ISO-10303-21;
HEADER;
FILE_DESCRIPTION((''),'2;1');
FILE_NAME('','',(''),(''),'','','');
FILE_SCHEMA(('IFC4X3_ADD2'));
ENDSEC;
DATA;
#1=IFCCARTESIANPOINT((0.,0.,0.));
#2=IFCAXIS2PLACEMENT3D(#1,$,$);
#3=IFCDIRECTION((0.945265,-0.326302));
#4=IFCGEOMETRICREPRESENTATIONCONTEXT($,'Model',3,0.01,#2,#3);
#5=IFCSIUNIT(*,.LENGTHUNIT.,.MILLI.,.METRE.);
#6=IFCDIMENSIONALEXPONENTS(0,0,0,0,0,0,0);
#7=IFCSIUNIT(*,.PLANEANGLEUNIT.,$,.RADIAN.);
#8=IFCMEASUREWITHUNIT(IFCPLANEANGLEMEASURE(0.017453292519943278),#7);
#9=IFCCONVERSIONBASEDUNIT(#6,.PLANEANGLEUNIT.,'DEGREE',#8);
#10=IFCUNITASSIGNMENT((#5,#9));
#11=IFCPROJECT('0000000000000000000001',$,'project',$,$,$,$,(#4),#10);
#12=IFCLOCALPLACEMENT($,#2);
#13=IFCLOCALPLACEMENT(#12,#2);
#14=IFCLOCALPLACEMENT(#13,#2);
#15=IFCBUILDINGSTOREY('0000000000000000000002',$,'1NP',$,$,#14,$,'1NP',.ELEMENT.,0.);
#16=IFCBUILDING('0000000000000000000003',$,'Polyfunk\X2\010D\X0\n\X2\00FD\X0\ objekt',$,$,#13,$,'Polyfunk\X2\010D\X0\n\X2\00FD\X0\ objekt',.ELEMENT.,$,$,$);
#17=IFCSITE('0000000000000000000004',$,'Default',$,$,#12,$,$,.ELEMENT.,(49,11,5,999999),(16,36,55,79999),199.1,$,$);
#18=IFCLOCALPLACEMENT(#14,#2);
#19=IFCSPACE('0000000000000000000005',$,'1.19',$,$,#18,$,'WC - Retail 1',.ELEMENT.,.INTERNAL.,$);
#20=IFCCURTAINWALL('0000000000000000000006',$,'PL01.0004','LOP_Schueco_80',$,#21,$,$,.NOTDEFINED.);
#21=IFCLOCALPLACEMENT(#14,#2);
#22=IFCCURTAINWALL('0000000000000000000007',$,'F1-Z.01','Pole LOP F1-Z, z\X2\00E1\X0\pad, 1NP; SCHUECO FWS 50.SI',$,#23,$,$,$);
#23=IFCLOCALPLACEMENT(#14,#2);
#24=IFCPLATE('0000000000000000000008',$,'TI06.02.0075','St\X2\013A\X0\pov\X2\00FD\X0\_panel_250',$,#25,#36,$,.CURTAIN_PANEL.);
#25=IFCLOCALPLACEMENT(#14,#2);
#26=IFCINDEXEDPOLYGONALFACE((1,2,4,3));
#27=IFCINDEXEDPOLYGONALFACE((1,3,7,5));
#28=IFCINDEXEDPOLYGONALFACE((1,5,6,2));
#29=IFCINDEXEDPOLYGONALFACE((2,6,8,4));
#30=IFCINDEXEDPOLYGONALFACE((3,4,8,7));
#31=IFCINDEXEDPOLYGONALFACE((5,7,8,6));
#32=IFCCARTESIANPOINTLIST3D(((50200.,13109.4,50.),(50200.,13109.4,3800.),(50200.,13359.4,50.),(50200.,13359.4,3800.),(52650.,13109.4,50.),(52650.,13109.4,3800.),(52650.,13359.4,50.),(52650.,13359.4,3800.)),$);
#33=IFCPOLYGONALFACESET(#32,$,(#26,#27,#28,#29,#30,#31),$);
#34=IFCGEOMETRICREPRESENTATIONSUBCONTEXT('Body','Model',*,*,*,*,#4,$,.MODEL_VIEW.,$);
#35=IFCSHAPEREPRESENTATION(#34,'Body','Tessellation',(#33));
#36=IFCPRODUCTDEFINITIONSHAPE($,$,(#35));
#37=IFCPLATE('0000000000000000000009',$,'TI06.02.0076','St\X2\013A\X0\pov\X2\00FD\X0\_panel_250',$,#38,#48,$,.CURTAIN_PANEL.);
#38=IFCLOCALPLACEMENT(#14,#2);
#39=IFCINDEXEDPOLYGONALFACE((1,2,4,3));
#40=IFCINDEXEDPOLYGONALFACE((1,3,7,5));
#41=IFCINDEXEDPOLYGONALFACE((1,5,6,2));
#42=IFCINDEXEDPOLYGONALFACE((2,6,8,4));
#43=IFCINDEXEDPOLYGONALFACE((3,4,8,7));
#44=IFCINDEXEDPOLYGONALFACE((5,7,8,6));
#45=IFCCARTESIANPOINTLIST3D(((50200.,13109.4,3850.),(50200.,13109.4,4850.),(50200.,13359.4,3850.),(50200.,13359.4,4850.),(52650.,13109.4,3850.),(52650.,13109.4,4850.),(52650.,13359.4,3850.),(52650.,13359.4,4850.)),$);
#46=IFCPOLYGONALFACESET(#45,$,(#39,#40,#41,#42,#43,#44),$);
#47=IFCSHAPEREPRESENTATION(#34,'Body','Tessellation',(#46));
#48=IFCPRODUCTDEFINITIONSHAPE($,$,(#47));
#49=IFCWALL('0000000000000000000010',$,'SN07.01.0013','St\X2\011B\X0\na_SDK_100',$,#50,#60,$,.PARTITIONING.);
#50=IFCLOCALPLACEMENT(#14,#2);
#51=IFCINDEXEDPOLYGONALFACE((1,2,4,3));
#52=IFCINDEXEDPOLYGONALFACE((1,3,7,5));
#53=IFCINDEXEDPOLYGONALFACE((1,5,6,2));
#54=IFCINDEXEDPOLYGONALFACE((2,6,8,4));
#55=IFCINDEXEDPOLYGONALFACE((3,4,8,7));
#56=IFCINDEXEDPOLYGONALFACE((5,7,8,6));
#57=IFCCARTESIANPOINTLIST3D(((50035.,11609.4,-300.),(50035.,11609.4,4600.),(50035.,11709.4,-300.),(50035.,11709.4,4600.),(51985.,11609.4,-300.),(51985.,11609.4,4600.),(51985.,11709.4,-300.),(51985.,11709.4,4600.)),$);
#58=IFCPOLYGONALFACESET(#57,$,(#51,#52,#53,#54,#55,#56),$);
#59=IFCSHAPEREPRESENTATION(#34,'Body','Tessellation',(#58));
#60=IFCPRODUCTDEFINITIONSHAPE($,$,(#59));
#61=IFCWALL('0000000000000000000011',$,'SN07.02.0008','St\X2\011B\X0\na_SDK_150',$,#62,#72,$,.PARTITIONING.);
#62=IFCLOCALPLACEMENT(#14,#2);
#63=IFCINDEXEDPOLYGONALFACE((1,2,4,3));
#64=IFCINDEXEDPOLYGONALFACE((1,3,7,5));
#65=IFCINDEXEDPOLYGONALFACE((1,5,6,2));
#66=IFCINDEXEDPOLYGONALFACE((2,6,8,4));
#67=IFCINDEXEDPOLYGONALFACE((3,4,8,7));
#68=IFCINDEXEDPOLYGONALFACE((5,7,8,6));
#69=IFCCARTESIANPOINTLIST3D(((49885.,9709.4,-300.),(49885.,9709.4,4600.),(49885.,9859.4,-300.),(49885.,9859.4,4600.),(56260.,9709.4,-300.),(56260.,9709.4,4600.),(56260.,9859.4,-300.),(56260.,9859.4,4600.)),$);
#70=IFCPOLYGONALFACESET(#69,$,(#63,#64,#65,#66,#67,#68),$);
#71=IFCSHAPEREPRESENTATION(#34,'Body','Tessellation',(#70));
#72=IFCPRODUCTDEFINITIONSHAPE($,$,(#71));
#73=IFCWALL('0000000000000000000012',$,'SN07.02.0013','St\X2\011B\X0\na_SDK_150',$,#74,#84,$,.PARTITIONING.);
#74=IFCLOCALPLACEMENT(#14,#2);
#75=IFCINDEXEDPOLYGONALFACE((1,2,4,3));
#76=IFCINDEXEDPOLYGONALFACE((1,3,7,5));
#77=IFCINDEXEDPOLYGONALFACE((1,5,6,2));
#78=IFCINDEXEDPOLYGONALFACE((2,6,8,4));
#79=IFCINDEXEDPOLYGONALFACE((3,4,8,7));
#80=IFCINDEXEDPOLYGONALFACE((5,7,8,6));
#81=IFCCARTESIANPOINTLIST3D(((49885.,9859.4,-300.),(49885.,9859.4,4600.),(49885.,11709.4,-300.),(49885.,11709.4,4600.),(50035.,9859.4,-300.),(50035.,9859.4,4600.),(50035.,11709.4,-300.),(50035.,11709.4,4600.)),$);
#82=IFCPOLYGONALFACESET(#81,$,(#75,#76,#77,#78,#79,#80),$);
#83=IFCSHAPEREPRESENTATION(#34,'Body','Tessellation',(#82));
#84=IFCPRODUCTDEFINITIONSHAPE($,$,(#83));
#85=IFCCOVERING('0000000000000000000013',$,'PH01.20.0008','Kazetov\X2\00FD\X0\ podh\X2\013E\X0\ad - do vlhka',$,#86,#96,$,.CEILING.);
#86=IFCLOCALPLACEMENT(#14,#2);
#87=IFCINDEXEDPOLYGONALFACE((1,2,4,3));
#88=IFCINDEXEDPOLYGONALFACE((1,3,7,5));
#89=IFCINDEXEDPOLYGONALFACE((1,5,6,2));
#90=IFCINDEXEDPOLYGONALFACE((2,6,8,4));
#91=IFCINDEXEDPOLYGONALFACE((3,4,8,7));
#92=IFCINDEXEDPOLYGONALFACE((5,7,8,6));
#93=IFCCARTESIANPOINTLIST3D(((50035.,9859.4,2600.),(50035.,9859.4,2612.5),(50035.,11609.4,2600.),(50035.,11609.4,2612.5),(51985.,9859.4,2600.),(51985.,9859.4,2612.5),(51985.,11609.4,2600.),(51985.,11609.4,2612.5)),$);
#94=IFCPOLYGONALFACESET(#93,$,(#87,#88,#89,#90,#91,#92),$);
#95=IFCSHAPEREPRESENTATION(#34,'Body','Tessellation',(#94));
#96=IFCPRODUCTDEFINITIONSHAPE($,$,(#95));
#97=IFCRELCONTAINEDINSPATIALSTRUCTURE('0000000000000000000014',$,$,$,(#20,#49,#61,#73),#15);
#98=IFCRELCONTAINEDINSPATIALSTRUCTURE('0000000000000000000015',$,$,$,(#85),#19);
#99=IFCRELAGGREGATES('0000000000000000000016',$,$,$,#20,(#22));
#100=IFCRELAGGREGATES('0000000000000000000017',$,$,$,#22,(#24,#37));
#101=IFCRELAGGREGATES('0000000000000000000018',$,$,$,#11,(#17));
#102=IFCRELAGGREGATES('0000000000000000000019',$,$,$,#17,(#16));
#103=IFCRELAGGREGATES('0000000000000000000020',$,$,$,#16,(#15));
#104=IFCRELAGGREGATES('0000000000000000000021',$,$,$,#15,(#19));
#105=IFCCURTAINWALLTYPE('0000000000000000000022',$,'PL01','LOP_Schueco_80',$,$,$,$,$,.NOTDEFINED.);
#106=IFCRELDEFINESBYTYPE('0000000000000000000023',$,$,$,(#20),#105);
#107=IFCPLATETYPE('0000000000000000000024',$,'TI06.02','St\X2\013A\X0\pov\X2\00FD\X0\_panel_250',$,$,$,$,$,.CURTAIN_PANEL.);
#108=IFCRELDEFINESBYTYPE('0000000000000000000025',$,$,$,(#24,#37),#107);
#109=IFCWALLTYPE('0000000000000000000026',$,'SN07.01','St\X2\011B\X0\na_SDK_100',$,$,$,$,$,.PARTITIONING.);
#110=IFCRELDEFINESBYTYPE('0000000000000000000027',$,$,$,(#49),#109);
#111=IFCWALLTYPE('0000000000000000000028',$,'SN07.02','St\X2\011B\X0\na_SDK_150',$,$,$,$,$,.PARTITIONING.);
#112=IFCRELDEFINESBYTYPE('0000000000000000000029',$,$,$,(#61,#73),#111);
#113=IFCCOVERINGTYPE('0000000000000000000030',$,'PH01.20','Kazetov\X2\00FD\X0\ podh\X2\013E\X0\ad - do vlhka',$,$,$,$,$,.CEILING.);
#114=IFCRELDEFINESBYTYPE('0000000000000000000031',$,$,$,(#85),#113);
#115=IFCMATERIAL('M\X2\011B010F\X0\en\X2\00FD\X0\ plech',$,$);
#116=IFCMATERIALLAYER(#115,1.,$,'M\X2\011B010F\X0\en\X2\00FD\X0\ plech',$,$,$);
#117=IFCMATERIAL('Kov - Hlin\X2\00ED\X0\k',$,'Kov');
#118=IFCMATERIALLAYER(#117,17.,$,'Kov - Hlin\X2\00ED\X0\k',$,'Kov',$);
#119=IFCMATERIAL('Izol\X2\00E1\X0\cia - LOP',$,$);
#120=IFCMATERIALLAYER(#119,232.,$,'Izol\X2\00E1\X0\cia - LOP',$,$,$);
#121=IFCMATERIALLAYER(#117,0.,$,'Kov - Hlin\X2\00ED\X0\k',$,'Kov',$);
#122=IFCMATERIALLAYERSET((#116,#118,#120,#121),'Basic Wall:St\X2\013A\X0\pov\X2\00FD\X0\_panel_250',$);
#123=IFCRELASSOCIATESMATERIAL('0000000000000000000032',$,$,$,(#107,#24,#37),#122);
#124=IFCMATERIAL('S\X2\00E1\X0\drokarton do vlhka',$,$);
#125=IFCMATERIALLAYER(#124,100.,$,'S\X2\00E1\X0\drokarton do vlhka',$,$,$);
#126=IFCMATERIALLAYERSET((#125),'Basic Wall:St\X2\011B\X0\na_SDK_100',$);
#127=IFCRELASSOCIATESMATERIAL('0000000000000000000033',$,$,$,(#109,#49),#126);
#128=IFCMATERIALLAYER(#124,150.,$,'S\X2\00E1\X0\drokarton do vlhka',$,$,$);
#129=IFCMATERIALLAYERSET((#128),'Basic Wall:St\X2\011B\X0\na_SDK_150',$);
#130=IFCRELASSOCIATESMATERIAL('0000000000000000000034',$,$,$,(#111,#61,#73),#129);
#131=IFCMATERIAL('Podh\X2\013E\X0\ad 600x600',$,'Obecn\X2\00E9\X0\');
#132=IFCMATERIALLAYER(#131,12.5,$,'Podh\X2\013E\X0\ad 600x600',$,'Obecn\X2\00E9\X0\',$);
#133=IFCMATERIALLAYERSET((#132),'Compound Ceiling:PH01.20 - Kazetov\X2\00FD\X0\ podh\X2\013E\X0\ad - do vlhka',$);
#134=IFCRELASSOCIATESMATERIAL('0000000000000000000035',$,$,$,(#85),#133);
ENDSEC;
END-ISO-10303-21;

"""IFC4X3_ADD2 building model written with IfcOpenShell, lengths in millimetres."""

from ifc_helpers import new_model, entity, si_unit, converted_unit, direction, frame, frame_2d, origin, origin_2d_with_axis, place, context, subcontext, project, spatial, polyline, rectangle, extrude, clip, bounded_halfspace, material, layer, layer_set, layer_usage, type_object, element, aggregate, save


model = new_model("IFC4X3_ADD2")

# Units and contexts
model_context = context("Model", 3, precision=0.01, world=origin(), true_north=direction((0.945265, -0.326302)))
body_context = subcontext(model_context, "Body", "Model", "MODEL_VIEW")
ifc_project = project(units=[si_unit("LENGTHUNIT", "METRE", prefix="MILLI"), converted_unit("PLANEANGLEUNIT", "DEGREE", entity("IfcPlaneAngleMeasure", 0.017453292519943278), si_unit("PLANEANGLEUNIT", "RADIAN"), dimensions=[0, 0, 0, 0, 0, 0, 0])], contexts=[model_context])

# Site, building, storey
site_placement = place(None, origin())
site = spatial("IfcSite", under=ifc_project, at=site_placement, Name="Default", CompositionType="ELEMENT", RefLatitude=(49, 11, 5, 999999), RefLongitude=(16, 36, 55, 79999), RefElevation=199.1)
building_placement = place(site_placement, origin())
building = spatial("IfcBuilding", under=site, at=building_placement, Name="Polyfunkčný objekt", LongName="Polyfunkčný objekt", CompositionType="ELEMENT")
storey_placement = place(building_placement, origin())
storey = spatial("IfcBuildingStorey", under=building, at=storey_placement, Name="1NP", LongName="1NP", CompositionType="ELEMENT", Elevation=0.0)

# Curtain walls, plates
curtain_wall_type = type_object("IfcCurtainWallType", Name="PL01", Description="LOP_Schueco_80", PredefinedType="NOTDEFINED")
curtain_wall_1_placement = place(storey_placement, origin())
curtain_wall_1 = element("IfcCurtainWall", 1, at=curtain_wall_1_placement, inside=storey, type_object=curtain_wall_type, Name="PL01.0004", Description="LOP_Schueco_80", PredefinedType="NOTDEFINED")
curtain_wall_2 = element("IfcCurtainWall", 2, Name="F1-Z.01", Description="Pole LOP F1-Z, západ, 1NP; SCHUECO FWS 50.SI")
aggregate(curtain_wall_1, [curtain_wall_2])
ifc_material_1 = material(Name="Měďený plech")
ifc_layer_1 = layer(ifc_material_1, 1.0, Name="Měďený plech")
ifc_material_2 = material(Name="Kov - Hliník", Category="Kov")
ifc_layer_2 = layer(ifc_material_2, 17.0, Name="Kov - Hliník", Category="Kov")
ifc_material_3 = material(Name="Izolácia - LOP")
ifc_layer_3 = layer(ifc_material_3, 232.0, Name="Izolácia - LOP")
ifc_layer_4 = layer(ifc_material_2, 0.0, Name="Kov - Hliník", Category="Kov")
ifc_layer_set_1 = layer_set([ifc_layer_1, ifc_layer_2, ifc_layer_3, ifc_layer_4], Name="Basic Wall:Stĺpový_panel_250")
ifc_layer_usage_1 = layer_usage(ifc_layer_set_1, "AXIS2", "NEGATIVE", 125.0)
plate_type = type_object("IfcPlateType", Name="TI06.02", Description="Stĺpový_panel_250", PredefinedType="CURTAIN_PANEL", material=ifc_layer_set_1)
plate_1_placement = place(storey_placement, frame((50200.0, 13234.4, 50.0)))
plate_1 = element("IfcPlate", 3, at=plate_1_placement, type_object=plate_type, material=ifc_layer_usage_1, Name="TI06.02.0075", Description="Stĺpový_panel_250", PredefinedType="CURTAIN_PANEL", context=body_context, shape_type="SweptSolid", body=[
    extrude(rectangle(XDim=250.0, YDim=2450.0, at=origin_2d_with_axis()), frame((1225.0, 0.0, 0.0), z_axis=(0.0, 0.0, 1.0), x_axis=(0.0, 1.0, 0.0)), (0.0, 0.0, 1.0), 3750.0),
])
ifc_layer_usage_2 = layer_usage(ifc_layer_set_1, "AXIS2", "NEGATIVE", 125.0)
plate_2_placement = place(storey_placement, frame((50200.0, 13234.4, 3850.0)))
plate_2 = element("IfcPlate", 4, at=plate_2_placement, type_object=plate_type, material=ifc_layer_usage_2, Name="TI06.02.0076", Description="Stĺpový_panel_250", PredefinedType="CURTAIN_PANEL", context=body_context, shape_type="SweptSolid", body=[
    extrude(rectangle(XDim=250.0, YDim=2450.0, at=origin_2d_with_axis()), frame((1225.0, 0.0, 0.0), z_axis=(0.0, 0.0, 1.0), x_axis=(0.0, 1.0, 0.0)), (0.0, 0.0, 1.0), 1000.0),
])
aggregate(curtain_wall_2, [plate_1, plate_2])

# Walls
ifc_material_4 = material(Name="Sádrokarton do vlhka")
ifc_layer_5 = layer(ifc_material_4, 100.0, Name="Sádrokarton do vlhka")
ifc_layer_set_2 = layer_set([ifc_layer_5], Name="Basic Wall:Stěna_SDK_100")
wall_type_1 = type_object("IfcWallType", Name="SN07.01", Description="Stěna_SDK_100", PredefinedType="PARTITIONING", material=ifc_layer_set_2)
wall_1_placement = place(storey_placement, frame((51985.0, 11659.4, -300.0), z_axis=(0.0, 0.0, 1.0), x_axis=(-1.0, 0.0, 0.0)))
element("IfcWall", 5, at=wall_1_placement, inside=storey, type_object=wall_type_1, material=ifc_layer_set_2, Name="SN07.01.0013", Description="Stěna_SDK_100", PredefinedType="PARTITIONING", context=body_context, shape_type="Clipping", body=[
    clip(clip(extrude(rectangle(XDim=1950.0, YDim=100.0, at=frame_2d((975.0, 0.0), x_axis=(-1.0, 0.0))), origin(), (0.0, 0.0, 1.0), 4900.0), bounded_halfspace(frame((0.0, -50.0, 4900.0), z_axis=(0.0, 0.0, -1.0), x_axis=(-1.0, 0.0, 0.0)), True, frame((0.0, -50.0, 4900.0)), polyline([(0.0, 0.0), (1950.0, 0.0), (1950.0, 100.0), (1050.0, 100.0), (900.0, 100.0), (0.0, 100.0), (0.0, 0.0)]))), bounded_halfspace(frame((1950.0, -50.0, 0.0), z_axis=(0.0, 0.0, 1.0), x_axis=(0.0, -1.0, 0.0)), True, frame((1950.0, -50.0, 0.0)), polyline([(0.0, 0.0), (0.0, 100.0), (-900.0, 100.0), (-1050.0, 100.0), (-1950.0, 100.0), (-1950.0, 0.0), (0.0, 0.0)]))),
])
ifc_layer_6 = layer(ifc_material_4, 150.0, Name="Sádrokarton do vlhka")
ifc_layer_set_3 = layer_set([ifc_layer_6], Name="Basic Wall:Stěna_SDK_150")
wall_type_2 = type_object("IfcWallType", Name="SN07.02", Description="Stěna_SDK_150", PredefinedType="PARTITIONING", material=ifc_layer_set_3)
wall_2_placement = place(storey_placement, frame((49885.0, 9784.4, -300.0)))
element("IfcWall", 6, at=wall_2_placement, inside=storey, type_object=wall_type_2, material=ifc_layer_set_3, Name="SN07.02.0008", Description="Stěna_SDK_150", PredefinedType="PARTITIONING", context=body_context, shape_type="Clipping", body=[
    clip(clip(extrude(rectangle(XDim=6375.0, YDim=150.0, at=frame_2d((3187.5, 0.0), x_axis=(-1.0, 0.0))), origin(), (0.0, 0.0, 1.0), 4900.0), bounded_halfspace(frame((0.0, -75.0, 4900.0), z_axis=(0.0, 0.0, -1.0), x_axis=(1.0, 0.0, 0.0)), True, frame((0.0, -75.0, 4900.0)), polyline([(0.0, 0.0), (6375.0, 0.0), (6375.0, 150.0), (2250.0, 150.0), (2100.0, 150.0), (1200.0, 150.0), (1050.0, 150.0), (150.0, 150.0), (0.0, 150.0), (0.0, 0.0)]))), bounded_halfspace(frame((6375.0, -75.0, 0.0), z_axis=(0.0, 0.0, 1.0), x_axis=(0.0, 1.0, 0.0)), True, frame((6375.0, -75.0, 0.0)), polyline([(0.0, 0.0), (0.0, 150.0), (-4125.0, 150.0), (-4275.0, 150.0), (-5175.0, 150.0), (-5325.0, 150.0), (-6225.0, 150.0), (-6375.0, 150.0), (-6375.0, 0.0), (0.0, 0.0)]))),
])
wall_3_placement = place(storey_placement, frame((49960.0, 9859.4, -300.0), z_axis=(0.0, 0.0, 1.0), x_axis=(0.0, 1.0, 0.0)))
element("IfcWall", 7, at=wall_3_placement, inside=storey, type_object=wall_type_2, material=ifc_layer_set_3, Name="SN07.02.0013", Description="Stěna_SDK_150", PredefinedType="PARTITIONING", context=body_context, shape_type="Clipping", body=[
    clip(clip(extrude(rectangle(XDim=1850.0, YDim=150.0, at=frame_2d((925.0, 0.0), x_axis=(-1.0, 0.0))), origin(), (0.0, 0.0, 1.0), 4900.0), bounded_halfspace(frame((0.0, -75.0, 4900.0), z_axis=(0.0, 0.0, -1.0), x_axis=(0.0, -1.0, 0.0)), True, frame((0.0, -75.0, 4900.0)), polyline([(0.0, 0.0), (1750.0, 0.0), (1850.0, 0.0), (1850.0, 150.0), (0.0, 150.0), (0.0, 0.0)]))), bounded_halfspace(frame((1850.0, -75.0, 0.0)), True, frame((1850.0, -75.0, 0.0)), polyline([(0.0, 0.0), (0.0, 150.0), (-1850.0, 150.0), (-1850.0, 0.0), (-100.0, 0.0), (0.0, 0.0)]))),
])

# Shared definitions
ifc_material_5 = material(Name="Podhľad 600x600", Category="Obecné")

# Shared definitions
space_1_placement = place(storey_placement, origin())
space_1 = spatial("IfcSpace", under=storey, at=space_1_placement, Name="1.19", LongName="WC - Retail 1", CompositionType="ELEMENT", PredefinedType="INTERNAL")

# Covering
ifc_layer_7 = layer(ifc_material_5, 12.5, Name="Podhľad 600x600", Category="Obecné")
ifc_layer_set_4 = layer_set([ifc_layer_7], Name="Compound Ceiling:PH01.20 - Kazetový podhľad - do vlhka")
ifc_layer_usage_3 = layer_usage(ifc_layer_set_4, "AXIS3", "NEGATIVE", 0.0)
covering_type_1 = type_object("IfcCoveringType", Name="PH01.20", Description="Kazetový podhľad - do vlhka", PredefinedType="CEILING")
covering_1_placement = place(storey_placement, frame((50035.0, 9859.4, 2600.0)))
element("IfcCovering", 8, at=covering_1_placement, inside=space_1, type_object=covering_type_1, material=ifc_layer_usage_3, Name="PH01.20.0008", Description="Kazetový podhľad - do vlhka", PredefinedType="CEILING", context=body_context, shape_type="SweptSolid", body=[
    extrude(rectangle(XDim=1950.0, YDim=1750.0, at=origin_2d_with_axis()), frame((975.0, 875.0, 0.0), z_axis=(0.0, 0.0, 1.0), x_axis=(-1.0, 0.0, 0.0)), (0.0, 0.0, 1.0), 12.5),
])

save(model, "model.ifc")
